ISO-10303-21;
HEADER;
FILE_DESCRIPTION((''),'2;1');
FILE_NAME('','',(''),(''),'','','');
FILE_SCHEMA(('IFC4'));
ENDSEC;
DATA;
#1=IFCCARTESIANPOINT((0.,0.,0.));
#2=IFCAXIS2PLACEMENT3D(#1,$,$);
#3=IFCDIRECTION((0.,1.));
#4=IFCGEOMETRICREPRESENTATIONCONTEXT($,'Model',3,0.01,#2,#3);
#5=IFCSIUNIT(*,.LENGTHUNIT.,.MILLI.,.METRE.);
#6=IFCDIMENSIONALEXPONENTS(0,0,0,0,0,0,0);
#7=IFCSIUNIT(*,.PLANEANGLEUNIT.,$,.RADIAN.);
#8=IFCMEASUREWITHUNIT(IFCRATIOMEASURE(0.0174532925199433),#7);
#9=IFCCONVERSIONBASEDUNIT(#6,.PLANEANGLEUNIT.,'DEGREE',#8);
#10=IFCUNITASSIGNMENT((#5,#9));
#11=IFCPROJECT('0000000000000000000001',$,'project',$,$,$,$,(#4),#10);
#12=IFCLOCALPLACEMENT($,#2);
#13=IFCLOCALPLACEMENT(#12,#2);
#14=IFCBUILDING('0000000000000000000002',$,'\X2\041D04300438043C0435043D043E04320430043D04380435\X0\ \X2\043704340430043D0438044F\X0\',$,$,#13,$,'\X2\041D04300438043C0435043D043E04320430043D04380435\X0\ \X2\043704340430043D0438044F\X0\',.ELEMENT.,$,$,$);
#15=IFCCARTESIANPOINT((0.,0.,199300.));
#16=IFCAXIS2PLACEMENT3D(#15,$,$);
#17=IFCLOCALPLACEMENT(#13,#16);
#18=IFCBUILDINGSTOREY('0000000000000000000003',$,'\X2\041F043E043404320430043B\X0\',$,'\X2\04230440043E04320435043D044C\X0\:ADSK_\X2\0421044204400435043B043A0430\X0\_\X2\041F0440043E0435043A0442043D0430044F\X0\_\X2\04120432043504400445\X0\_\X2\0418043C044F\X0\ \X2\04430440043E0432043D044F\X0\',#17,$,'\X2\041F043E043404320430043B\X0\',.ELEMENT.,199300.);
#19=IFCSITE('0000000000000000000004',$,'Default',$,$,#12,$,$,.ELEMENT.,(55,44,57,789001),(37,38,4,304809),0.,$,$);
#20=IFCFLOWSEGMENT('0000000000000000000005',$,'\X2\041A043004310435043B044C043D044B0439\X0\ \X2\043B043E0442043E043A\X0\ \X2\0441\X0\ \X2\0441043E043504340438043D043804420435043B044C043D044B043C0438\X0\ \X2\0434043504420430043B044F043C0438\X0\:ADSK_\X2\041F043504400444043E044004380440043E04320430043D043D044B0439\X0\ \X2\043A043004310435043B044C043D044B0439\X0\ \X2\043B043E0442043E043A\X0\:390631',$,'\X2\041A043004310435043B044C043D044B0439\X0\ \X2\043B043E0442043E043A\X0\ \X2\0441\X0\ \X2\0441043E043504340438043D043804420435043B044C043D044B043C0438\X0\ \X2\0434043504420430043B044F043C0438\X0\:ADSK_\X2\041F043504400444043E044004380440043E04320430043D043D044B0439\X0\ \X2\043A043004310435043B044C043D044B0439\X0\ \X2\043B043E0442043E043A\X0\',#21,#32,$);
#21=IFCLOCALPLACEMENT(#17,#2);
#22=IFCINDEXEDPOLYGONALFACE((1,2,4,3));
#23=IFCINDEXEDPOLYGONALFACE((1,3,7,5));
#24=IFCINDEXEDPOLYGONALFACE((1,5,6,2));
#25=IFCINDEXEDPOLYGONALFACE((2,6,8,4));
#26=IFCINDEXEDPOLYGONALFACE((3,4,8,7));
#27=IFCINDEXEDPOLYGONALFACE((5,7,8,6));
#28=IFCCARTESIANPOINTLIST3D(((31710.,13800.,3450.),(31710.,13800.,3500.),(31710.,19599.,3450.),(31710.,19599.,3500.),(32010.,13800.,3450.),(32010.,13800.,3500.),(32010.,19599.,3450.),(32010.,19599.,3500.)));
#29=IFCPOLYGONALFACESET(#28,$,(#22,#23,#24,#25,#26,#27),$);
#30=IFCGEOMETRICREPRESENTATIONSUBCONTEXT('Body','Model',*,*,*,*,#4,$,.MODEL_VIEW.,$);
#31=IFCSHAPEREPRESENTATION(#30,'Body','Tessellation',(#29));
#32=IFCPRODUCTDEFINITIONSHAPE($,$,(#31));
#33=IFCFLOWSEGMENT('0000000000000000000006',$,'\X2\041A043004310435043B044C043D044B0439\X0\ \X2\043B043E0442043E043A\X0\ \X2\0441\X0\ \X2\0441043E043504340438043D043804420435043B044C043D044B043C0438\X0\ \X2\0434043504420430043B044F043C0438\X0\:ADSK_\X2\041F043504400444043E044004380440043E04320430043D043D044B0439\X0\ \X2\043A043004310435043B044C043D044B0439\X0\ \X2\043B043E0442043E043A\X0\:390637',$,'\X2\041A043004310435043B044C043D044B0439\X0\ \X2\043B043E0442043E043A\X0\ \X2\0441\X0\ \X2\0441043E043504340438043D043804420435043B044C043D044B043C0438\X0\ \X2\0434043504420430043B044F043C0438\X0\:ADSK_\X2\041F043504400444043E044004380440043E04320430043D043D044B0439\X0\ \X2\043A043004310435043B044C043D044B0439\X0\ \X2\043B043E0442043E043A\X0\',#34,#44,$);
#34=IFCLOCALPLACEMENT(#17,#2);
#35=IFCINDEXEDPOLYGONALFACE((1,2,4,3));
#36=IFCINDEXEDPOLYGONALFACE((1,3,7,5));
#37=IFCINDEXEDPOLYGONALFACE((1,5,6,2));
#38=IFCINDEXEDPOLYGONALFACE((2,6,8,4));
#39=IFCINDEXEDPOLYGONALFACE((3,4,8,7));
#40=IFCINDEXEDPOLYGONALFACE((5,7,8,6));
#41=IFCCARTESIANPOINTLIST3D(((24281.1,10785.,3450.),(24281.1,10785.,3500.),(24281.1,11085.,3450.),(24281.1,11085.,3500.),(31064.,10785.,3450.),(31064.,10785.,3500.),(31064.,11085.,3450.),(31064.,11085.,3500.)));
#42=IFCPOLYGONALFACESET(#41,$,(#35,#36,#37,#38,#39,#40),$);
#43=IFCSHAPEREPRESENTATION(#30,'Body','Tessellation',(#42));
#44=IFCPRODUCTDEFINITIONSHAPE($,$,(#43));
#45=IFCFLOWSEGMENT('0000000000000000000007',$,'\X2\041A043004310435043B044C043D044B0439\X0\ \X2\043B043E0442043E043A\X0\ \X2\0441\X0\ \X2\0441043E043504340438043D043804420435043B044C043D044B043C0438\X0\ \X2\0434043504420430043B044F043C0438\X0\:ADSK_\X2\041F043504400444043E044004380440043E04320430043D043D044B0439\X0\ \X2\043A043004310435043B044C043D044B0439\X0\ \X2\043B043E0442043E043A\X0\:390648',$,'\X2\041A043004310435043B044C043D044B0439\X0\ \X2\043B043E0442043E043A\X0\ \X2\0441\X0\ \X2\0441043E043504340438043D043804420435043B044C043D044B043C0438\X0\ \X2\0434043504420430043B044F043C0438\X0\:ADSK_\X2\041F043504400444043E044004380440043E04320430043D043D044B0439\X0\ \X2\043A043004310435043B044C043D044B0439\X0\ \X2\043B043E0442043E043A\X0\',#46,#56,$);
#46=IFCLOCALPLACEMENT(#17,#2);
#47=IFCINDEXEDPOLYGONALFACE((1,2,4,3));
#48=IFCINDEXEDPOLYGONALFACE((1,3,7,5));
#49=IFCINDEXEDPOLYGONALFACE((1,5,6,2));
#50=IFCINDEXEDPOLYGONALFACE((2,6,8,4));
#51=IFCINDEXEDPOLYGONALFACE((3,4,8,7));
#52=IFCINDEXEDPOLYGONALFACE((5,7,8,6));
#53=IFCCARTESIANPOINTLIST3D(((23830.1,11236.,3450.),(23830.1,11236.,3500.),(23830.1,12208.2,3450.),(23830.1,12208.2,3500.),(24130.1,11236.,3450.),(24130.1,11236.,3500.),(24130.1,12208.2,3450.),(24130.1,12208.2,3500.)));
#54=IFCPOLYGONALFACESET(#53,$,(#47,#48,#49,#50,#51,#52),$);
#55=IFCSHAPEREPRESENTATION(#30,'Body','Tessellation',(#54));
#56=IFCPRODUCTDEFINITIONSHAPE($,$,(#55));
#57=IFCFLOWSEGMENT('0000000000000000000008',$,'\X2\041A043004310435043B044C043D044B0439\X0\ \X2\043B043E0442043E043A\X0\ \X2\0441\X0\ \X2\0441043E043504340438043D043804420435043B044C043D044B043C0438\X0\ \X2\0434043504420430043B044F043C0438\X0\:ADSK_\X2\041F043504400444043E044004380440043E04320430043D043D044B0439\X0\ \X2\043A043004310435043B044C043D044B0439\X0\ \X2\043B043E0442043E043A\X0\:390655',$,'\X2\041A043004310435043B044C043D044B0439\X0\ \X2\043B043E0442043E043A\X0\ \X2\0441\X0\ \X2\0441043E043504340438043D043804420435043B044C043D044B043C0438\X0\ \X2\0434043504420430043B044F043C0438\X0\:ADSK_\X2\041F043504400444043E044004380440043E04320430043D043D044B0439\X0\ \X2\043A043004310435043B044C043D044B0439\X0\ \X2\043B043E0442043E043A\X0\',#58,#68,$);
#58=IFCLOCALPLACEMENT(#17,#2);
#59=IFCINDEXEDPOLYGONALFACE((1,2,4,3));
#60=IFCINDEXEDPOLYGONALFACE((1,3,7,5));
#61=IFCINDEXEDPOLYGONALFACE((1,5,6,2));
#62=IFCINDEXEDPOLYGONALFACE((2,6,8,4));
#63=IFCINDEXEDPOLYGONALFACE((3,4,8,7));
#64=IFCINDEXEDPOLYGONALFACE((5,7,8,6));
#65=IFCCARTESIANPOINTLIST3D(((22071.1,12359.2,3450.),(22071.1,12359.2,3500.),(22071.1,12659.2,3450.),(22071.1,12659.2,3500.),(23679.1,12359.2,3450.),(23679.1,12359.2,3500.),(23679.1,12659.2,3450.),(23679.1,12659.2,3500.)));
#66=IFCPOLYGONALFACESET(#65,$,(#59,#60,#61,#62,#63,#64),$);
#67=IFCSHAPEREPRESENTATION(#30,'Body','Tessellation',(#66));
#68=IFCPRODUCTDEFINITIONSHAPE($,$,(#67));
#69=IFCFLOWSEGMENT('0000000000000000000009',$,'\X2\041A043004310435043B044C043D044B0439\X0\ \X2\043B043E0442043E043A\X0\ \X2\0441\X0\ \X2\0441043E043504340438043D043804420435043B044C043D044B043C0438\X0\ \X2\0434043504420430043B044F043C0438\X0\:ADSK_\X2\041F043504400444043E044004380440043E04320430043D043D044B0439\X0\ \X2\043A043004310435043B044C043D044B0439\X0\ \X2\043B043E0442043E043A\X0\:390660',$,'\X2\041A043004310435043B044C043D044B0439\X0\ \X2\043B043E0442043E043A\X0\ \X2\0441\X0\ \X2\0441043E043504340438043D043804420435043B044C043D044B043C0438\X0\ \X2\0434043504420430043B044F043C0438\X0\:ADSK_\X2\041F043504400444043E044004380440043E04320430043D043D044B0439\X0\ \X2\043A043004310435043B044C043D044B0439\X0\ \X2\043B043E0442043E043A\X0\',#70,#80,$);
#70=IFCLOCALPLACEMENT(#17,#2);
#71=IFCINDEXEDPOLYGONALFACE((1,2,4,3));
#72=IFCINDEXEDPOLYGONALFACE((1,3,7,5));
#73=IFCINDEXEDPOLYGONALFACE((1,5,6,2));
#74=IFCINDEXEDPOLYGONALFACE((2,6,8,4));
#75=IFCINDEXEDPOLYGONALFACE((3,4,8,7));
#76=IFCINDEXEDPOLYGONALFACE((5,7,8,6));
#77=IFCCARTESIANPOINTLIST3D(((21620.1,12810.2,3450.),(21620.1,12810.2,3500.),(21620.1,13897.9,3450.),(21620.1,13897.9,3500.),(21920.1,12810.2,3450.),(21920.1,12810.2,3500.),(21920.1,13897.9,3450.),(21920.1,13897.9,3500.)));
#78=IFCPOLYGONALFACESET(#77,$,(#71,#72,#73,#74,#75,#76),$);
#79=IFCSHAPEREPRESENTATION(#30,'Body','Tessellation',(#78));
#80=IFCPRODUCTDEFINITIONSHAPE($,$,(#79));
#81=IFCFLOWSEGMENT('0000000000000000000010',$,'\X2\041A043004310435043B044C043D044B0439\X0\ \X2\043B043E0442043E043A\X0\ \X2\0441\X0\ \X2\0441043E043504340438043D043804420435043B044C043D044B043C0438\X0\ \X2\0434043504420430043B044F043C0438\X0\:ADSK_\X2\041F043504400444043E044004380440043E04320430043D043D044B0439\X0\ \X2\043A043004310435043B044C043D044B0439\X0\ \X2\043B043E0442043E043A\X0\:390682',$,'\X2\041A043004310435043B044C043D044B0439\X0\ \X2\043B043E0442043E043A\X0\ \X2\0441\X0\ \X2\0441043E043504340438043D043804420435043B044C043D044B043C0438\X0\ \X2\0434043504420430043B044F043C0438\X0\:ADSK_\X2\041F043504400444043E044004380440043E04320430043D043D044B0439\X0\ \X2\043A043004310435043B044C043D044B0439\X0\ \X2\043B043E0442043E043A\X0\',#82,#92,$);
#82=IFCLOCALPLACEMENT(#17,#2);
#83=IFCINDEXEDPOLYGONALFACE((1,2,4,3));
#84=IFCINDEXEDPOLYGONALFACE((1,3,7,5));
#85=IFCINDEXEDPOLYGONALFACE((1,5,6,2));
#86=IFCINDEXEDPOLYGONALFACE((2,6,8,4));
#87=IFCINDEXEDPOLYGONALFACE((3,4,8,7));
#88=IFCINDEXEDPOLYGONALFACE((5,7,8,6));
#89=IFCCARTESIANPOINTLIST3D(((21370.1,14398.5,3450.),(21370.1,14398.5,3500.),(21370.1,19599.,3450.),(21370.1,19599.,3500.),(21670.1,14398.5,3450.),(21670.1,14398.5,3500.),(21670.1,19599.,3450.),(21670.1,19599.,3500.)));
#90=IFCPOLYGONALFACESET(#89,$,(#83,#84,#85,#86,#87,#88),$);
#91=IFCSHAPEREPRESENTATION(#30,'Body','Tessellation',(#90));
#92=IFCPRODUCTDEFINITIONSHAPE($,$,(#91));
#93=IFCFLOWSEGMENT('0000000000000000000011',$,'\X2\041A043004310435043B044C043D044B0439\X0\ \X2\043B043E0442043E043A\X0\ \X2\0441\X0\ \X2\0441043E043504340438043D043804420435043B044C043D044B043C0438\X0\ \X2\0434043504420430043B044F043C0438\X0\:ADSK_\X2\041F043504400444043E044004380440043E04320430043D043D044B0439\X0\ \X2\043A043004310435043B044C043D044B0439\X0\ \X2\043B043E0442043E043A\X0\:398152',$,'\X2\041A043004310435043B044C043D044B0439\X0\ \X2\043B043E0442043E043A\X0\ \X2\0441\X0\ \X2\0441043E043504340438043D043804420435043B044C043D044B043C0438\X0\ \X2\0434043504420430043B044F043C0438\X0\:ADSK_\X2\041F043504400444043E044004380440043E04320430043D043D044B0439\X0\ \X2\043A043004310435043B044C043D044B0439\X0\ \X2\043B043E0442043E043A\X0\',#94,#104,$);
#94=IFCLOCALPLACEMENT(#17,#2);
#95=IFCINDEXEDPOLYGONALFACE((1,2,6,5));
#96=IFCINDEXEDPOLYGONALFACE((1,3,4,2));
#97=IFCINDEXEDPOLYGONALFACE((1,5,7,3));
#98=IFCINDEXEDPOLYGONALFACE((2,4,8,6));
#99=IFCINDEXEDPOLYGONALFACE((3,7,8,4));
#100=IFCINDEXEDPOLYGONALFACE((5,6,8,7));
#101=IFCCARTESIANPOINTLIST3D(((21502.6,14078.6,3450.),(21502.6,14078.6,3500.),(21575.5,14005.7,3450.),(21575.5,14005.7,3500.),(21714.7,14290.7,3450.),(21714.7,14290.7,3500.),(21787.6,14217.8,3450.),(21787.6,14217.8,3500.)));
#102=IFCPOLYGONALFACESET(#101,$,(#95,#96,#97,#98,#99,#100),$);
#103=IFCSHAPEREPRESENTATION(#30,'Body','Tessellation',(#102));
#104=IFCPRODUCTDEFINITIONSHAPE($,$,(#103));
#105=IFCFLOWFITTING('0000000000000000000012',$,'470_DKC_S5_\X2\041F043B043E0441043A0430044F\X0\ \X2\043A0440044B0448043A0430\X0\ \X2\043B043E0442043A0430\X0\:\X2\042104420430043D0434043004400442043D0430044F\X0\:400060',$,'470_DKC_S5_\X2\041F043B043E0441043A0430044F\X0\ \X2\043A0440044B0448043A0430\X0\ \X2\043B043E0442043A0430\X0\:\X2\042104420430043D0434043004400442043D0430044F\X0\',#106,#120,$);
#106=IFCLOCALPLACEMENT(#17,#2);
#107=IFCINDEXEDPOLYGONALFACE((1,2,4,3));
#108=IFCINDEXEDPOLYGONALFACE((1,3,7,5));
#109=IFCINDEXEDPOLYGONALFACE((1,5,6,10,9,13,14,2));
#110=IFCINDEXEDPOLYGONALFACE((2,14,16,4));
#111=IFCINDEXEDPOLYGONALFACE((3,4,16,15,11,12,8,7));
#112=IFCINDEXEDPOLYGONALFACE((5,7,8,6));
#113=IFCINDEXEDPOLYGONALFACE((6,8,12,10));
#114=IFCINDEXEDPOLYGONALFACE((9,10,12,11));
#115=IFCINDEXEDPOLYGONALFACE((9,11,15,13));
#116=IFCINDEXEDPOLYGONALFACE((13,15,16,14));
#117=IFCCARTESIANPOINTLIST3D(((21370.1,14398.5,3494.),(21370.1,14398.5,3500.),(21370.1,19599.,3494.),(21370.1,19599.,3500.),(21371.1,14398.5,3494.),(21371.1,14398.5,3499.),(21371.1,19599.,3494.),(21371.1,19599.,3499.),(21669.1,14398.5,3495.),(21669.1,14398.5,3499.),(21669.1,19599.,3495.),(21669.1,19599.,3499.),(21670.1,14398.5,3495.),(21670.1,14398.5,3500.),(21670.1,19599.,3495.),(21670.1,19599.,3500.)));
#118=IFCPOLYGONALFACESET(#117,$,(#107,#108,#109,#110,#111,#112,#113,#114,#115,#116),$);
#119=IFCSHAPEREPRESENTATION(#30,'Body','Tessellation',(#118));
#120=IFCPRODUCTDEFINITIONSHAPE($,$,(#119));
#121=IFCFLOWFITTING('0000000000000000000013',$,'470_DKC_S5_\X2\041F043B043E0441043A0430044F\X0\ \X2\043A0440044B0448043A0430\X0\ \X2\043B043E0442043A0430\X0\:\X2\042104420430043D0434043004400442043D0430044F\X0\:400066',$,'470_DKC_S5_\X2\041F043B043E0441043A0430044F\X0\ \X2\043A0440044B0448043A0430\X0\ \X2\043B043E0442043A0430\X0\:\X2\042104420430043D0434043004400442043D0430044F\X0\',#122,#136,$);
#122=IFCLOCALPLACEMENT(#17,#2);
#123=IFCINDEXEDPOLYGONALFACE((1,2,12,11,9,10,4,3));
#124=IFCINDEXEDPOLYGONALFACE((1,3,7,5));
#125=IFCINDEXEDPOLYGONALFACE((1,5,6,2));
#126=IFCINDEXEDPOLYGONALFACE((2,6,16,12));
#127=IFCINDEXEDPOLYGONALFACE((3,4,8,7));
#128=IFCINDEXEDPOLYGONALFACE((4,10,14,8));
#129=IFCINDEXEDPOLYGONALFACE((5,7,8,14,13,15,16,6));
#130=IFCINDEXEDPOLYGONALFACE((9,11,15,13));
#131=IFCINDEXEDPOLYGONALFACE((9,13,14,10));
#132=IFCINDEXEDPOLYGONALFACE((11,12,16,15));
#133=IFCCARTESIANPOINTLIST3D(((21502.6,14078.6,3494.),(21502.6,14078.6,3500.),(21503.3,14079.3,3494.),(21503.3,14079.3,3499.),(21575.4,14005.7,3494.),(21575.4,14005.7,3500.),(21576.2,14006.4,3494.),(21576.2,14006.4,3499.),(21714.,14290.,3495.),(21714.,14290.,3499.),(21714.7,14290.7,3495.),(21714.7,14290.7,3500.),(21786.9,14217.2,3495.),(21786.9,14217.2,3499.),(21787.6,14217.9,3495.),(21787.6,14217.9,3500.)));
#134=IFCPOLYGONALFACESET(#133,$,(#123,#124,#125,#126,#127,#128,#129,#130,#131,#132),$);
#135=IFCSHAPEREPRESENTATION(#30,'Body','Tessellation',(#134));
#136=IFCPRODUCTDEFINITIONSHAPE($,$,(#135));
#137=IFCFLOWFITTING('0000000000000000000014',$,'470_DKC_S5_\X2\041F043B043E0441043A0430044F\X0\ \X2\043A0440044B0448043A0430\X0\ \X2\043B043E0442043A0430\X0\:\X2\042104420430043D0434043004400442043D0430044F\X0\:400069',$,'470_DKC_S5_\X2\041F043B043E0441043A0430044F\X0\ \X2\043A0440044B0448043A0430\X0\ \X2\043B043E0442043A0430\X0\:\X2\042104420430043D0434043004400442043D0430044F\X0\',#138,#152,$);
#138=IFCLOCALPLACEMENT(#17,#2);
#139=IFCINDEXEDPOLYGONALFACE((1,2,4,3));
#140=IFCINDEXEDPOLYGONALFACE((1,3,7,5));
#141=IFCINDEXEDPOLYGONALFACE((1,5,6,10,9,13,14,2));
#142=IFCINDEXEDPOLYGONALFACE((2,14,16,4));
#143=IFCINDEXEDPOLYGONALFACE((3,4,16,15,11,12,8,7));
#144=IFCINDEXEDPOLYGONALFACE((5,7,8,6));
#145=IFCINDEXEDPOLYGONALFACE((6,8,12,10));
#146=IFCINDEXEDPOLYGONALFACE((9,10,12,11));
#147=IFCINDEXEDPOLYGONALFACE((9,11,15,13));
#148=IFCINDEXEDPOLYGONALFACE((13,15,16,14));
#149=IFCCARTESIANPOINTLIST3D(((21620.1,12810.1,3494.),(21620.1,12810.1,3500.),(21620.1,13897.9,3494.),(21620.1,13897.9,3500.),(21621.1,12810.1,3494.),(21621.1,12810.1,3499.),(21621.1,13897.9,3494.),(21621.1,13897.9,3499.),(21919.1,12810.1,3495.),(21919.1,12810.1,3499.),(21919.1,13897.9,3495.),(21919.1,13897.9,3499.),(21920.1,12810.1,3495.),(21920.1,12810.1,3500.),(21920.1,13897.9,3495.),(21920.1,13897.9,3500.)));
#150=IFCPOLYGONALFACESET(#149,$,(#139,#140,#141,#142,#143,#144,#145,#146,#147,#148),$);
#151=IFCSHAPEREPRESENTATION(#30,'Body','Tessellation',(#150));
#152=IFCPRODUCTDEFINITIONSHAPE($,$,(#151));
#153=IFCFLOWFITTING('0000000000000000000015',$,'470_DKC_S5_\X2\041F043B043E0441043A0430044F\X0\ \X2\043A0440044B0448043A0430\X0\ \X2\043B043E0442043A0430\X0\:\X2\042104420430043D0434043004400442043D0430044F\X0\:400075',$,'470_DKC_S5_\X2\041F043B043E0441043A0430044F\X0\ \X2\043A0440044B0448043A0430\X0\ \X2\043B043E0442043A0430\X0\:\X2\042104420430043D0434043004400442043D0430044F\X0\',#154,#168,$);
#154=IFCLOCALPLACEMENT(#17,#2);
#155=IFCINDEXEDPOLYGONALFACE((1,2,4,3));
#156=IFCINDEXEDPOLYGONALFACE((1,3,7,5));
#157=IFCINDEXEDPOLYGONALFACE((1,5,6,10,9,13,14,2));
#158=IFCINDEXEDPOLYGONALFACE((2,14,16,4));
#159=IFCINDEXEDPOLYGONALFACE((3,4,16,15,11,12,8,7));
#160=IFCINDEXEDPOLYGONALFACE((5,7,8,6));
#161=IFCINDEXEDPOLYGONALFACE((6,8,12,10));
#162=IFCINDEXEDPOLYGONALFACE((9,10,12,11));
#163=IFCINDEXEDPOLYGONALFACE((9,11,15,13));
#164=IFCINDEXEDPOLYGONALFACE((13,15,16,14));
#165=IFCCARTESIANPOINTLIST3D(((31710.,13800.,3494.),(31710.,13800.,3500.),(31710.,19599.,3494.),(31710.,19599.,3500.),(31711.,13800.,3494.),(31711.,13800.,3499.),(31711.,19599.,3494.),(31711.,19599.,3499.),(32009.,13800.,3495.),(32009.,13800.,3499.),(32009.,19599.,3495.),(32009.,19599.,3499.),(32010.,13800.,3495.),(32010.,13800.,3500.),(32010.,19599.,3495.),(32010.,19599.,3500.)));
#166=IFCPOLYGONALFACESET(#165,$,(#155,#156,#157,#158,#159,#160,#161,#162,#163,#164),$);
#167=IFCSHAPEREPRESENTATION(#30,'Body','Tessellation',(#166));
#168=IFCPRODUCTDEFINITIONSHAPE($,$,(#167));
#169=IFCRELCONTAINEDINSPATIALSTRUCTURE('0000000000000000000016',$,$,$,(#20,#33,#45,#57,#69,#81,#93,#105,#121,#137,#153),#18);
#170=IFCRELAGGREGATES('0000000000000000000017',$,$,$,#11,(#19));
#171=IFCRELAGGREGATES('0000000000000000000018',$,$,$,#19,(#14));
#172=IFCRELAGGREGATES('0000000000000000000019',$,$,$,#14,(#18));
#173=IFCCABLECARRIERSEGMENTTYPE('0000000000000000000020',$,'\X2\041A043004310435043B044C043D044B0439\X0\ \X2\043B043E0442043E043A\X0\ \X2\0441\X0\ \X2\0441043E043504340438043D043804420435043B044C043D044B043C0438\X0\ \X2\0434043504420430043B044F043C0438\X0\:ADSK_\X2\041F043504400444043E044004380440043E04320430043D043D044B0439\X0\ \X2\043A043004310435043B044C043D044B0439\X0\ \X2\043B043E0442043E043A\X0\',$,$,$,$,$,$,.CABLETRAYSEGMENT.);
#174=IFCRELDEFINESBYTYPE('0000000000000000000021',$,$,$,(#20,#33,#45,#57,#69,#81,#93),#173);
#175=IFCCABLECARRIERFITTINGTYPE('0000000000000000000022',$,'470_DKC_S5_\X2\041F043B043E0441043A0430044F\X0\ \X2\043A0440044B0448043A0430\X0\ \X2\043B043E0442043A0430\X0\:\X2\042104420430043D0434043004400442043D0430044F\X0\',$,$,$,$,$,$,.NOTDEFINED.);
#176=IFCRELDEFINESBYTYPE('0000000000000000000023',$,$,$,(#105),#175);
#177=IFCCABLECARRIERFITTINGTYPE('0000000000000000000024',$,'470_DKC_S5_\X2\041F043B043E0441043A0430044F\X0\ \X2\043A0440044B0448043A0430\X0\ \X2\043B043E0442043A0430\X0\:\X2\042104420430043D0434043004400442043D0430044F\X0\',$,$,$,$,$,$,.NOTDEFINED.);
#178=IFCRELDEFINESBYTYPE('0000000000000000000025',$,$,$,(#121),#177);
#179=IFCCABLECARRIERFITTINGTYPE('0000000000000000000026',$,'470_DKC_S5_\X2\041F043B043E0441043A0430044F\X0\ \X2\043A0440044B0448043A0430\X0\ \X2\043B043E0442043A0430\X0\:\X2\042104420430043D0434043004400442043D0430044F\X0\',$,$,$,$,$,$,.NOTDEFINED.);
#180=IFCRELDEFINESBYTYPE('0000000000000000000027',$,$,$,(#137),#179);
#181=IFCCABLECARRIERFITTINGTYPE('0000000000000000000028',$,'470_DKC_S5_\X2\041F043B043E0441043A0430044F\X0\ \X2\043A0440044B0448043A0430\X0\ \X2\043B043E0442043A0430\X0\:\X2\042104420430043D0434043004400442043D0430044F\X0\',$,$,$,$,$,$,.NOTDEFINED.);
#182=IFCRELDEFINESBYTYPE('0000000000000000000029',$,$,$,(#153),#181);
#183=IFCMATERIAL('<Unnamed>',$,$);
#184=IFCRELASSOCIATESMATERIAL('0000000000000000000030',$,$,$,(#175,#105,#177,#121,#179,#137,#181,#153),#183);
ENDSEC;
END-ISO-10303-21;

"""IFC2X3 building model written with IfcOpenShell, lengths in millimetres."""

from ifc_helpers import new_model, entity, si_unit, converted_unit, direction, frame, frame_2d, origin, origin_2d_with_axis, place, context, subcontext, project, spatial, polyline, rectangle, outline, extrude, source, transform, mapped, material, type_object, type_shapes, element, save


model = new_model("IFC2X3")

# Units and contexts
model_context = context("Model", 3, precision=0.01, world=origin(), true_north=direction((0.0, 1.0)))
body_context = subcontext(model_context, "Body", "Model", "MODEL_VIEW")
ifc_project = project(units=[si_unit("LENGTHUNIT", "METRE", prefix="MILLI"), converted_unit("PLANEANGLEUNIT", "DEGREE", entity("IfcRatioMeasure", 0.0174532925199433), si_unit("PLANEANGLEUNIT", "RADIAN"), dimensions=[0, 0, 0, 0, 0, 0, 0])], contexts=[model_context])

# Site, building, storey
site_placement = place(None, origin())
site = spatial("IfcSite", under=ifc_project, at=site_placement, Name="Default", CompositionType="ELEMENT", RefLatitude=(55, 44, 57, 789001), RefLongitude=(37, 38, 4, 304809), RefElevation=0.0)
building_placement = place(site_placement, origin())
building = spatial("IfcBuilding", under=site, at=building_placement, Name="Наименование здания", LongName="Наименование здания", CompositionType="ELEMENT")
storey_placement = place(building_placement, frame((0.0, 0.0, 199300.0)))
storey = spatial("IfcBuildingStorey", under=building, at=storey_placement, Name="Подвал", ObjectType="Уровень:ADSK_Стрелка_Проектная_Вверх_Имя уровня", LongName="Подвал", CompositionType="ELEMENT", Elevation=199300.0)

# Flow segments
cable_carrier_segment_type = type_object("IfcCableCarrierSegmentType", Name="Кабельный лоток с соединительными деталями:ADSK_Перфорированный кабельный лоток", PredefinedType="CABLETRAYSEGMENT")
flow_segment_1_placement = place(storey_placement, frame((31710.0, 13800.0, 3450.0)))
element("IfcFlowSegment", 1, at=flow_segment_1_placement, inside=storey, type_object=cable_carrier_segment_type, Name="Кабельный лоток с соединительными деталями:ADSK_Перфорированный кабельный лоток:390631", ObjectType="Кабельный лоток с соединительными деталями:ADSK_Перфорированный кабельный лоток", context=body_context, shape_type="SweptSolid", body=[
    extrude(rectangle(XDim=5799.0, YDim=300.0, at=origin_2d_with_axis()), frame((150.0, 2899.5, 0.0), z_axis=(0.0, 0.0, 1.0), x_axis=(0.0, -1.0, 0.0)), (0.0, 0.0, 1.0), 50.0),
])
flow_segment_2_placement = place(storey_placement, frame((24281.1, 10785.0, 3450.0)))
element("IfcFlowSegment", 2, at=flow_segment_2_placement, inside=storey, type_object=cable_carrier_segment_type, Name="Кабельный лоток с соединительными деталями:ADSK_Перфорированный кабельный лоток:390637", ObjectType="Кабельный лоток с соединительными деталями:ADSK_Перфорированный кабельный лоток", context=body_context, shape_type="SweptSolid", body=[
    extrude(rectangle(XDim=6782.9, YDim=300.0, at=frame_2d((0.0, 0.0), x_axis=(1.0, 0.0))), frame((3391.5, 150.0, 0.0), z_axis=(0.0, 0.0, 1.0), x_axis=(-1.0, 0.0, 0.0)), (0.0, 0.0, 1.0), 50.0),
])
flow_segment_3_placement = place(storey_placement, frame((23830.1, 11236.0, 3450.0)))
element("IfcFlowSegment", 3, at=flow_segment_3_placement, inside=storey, type_object=cable_carrier_segment_type, Name="Кабельный лоток с соединительными деталями:ADSK_Перфорированный кабельный лоток:390648", ObjectType="Кабельный лоток с соединительными деталями:ADSK_Перфорированный кабельный лоток", context=body_context, shape_type="SweptSolid", body=[
    extrude(rectangle(XDim=972.2, YDim=300.0, at=origin_2d_with_axis()), frame((150.0, 486.1, 0.0), z_axis=(0.0, 0.0, 1.0), x_axis=(0.0, 1.0, 0.0)), (0.0, 0.0, 1.0), 50.0),
])
flow_segment_4_placement = place(storey_placement, frame((22071.1, 12359.2, 3450.0)))
element("IfcFlowSegment", 4, at=flow_segment_4_placement, inside=storey, type_object=cable_carrier_segment_type, Name="Кабельный лоток с соединительными деталями:ADSK_Перфорированный кабельный лоток:390655", ObjectType="Кабельный лоток с соединительными деталями:ADSK_Перфорированный кабельный лоток", context=body_context, shape_type="SweptSolid", body=[
    extrude(rectangle(XDim=1608.0, YDim=300.0, at=frame_2d((0.0, 0.0), x_axis=(1.0, 0.0))), frame((804.0, 150.0, 0.0), z_axis=(0.0, 0.0, 1.0), x_axis=(-1.0, 0.0, 0.0)), (0.0, 0.0, 1.0), 50.0),
])
flow_segment_5_placement = place(storey_placement, frame((21620.1, 12810.2, 3450.0)))
element("IfcFlowSegment", 5, at=flow_segment_5_placement, inside=storey, type_object=cable_carrier_segment_type, Name="Кабельный лоток с соединительными деталями:ADSK_Перфорированный кабельный лоток:390660", ObjectType="Кабельный лоток с соединительными деталями:ADSK_Перфорированный кабельный лоток", context=body_context, shape_type="SweptSolid", body=[
    extrude(rectangle(XDim=1087.8, YDim=300.0, at=frame_2d((0.0, 0.0), x_axis=(1.0, 0.0))), frame((150.0, 543.9, 0.0), z_axis=(0.0, 0.0, 1.0), x_axis=(0.0, 1.0, 0.0)), (0.0, 0.0, 1.0), 50.0),
])
flow_segment_6_placement = place(storey_placement, frame((21370.1, 14398.5, 3450.0)))
element("IfcFlowSegment", 6, at=flow_segment_6_placement, inside=storey, type_object=cable_carrier_segment_type, Name="Кабельный лоток с соединительными деталями:ADSK_Перфорированный кабельный лоток:390682", ObjectType="Кабельный лоток с соединительными деталями:ADSK_Перфорированный кабельный лоток", context=body_context, shape_type="SweptSolid", body=[
    extrude(rectangle(XDim=5200.5, YDim=300.0, at=origin_2d_with_axis()), frame((150.0, 2600.3, 0.0), z_axis=(0.0, 0.0, 1.0), x_axis=(0.0, -1.0, 0.0)), (0.0, 0.0, 1.0), 50.0),
])
flow_segment_7_placement = place(storey_placement, frame((21502.6, 14005.7, 3450.0)))
element("IfcFlowSegment", 7, at=flow_segment_7_placement, inside=storey, type_object=cable_carrier_segment_type, Name="Кабельный лоток с соединительными деталями:ADSK_Перфорированный кабельный лоток:398152", ObjectType="Кабельный лоток с соединительными деталями:ADSK_Перфорированный кабельный лоток", context=body_context, shape_type="SweptSolid", body=[
    extrude(rectangle(XDim=103.0, YDim=300.0, at=frame_2d((0.0, 0.0), x_axis=(1.0, 0.0))), frame((142.5, 142.5, 0.0), z_axis=(0.0, 0.0, 1.0), x_axis=(-0.707107, 0.707107, 0.0)), (0.0, 0.0, 1.0), 50.0),
])

# Flow fittings
ifc_material = material(Name="<Unnamed>")
cable_carrier_fitting_type_1 = type_object("IfcCableCarrierFittingType", Name="470_DKC_S5_Плоская крышка лотка:Стандартная", PredefinedType="NOTDEFINED", material=ifc_material)
shared_shape_1 = source(origin(), body_context, "Body", "SweptSolid", [
    extrude(outline(polyline([(-150.0, -2.0), (-149.0, -2.0), (-149.0, 2.0), (149.0, 2.0), (149.0, -3.0), (150.0, -3.0), (150.0, 3.0), (-150.0, 3.0), (-150.0, -2.0)])), frame((0.0, 150.0, 3.0), z_axis=(1.0, 0.0, 0.0), x_axis=(0.0, 1.0, 0.0)), (0.0, 0.0, 1.0), 5200.5),
])
type_shapes(cable_carrier_fitting_type_1, [shared_shape_1])
flow_fitting_1_placement = place(storey_placement, frame((21670.1, 14398.5, 3494.0), z_axis=(0.0, 0.0, 1.0), x_axis=(0.0, 1.0, 0.0)))
element("IfcFlowFitting", 8, at=flow_fitting_1_placement, inside=storey, type_object=cable_carrier_fitting_type_1, material=ifc_material, Name="470_DKC_S5_Плоская крышка лотка:Стандартная:400060", ObjectType="470_DKC_S5_Плоская крышка лотка:Стандартная", context=body_context, shape_type="MappedRepresentation", body=[
    mapped(shared_shape_1, transform((0.0, 0.0, 0.0), scale=1.0)),
])
cable_carrier_fitting_type_2 = type_object("IfcCableCarrierFittingType", Name="470_DKC_S5_Плоская крышка лотка:Стандартная", PredefinedType="NOTDEFINED", material=ifc_material)
shared_shape_2 = source(origin(), body_context, "Body", "SweptSolid", [
    extrude(outline(polyline([(-150.0, -2.0), (-149.0, -2.0), (-149.0, 2.0), (149.0, 2.0), (149.0, -3.0), (150.0, -3.0), (150.0, 3.0), (-150.0, 3.0), (-150.0, -2.0)])), frame((0.0, 150.0, 3.0), z_axis=(1.0, 0.0, 0.0), x_axis=(0.0, 1.0, 0.0)), (0.0, 0.0, 1.0), 103.0),
])
type_shapes(cable_carrier_fitting_type_2, [shared_shape_2])
flow_fitting_2_placement = place(storey_placement, frame((21787.6, 14217.9, 3494.0), z_axis=(0.0, 0.0, 1.0), x_axis=(-0.707107, 0.707107, 0.0)))
element("IfcFlowFitting", 9, at=flow_fitting_2_placement, inside=storey, type_object=cable_carrier_fitting_type_2, material=ifc_material, Name="470_DKC_S5_Плоская крышка лотка:Стандартная:400066", ObjectType="470_DKC_S5_Плоская крышка лотка:Стандартная", context=body_context, shape_type="MappedRepresentation", body=[
    mapped(shared_shape_2, transform((0.0, 0.0, 0.0), scale=1.0)),
])
cable_carrier_fitting_type_3 = type_object("IfcCableCarrierFittingType", Name="470_DKC_S5_Плоская крышка лотка:Стандартная", PredefinedType="NOTDEFINED", material=ifc_material)
shared_shape_3 = source(origin(), body_context, "Body", "SweptSolid", [
    extrude(outline(polyline([(-150.0, -2.0), (-149.0, -2.0), (-149.0, 2.0), (149.0, 2.0), (149.0, -3.0), (150.0, -3.0), (150.0, 3.0), (-150.0, 3.0), (-150.0, -2.0)])), frame((0.0, 150.0, 3.0), z_axis=(1.0, 0.0, 0.0), x_axis=(0.0, 1.0, 0.0)), (0.0, 0.0, 1.0), 1087.8),
])
type_shapes(cable_carrier_fitting_type_3, [shared_shape_3])
flow_fitting_3_placement = place(storey_placement, frame((21920.1, 12810.1, 3494.0), z_axis=(0.0, 0.0, 1.0), x_axis=(0.0, 1.0, 0.0)))
element("IfcFlowFitting", 10, at=flow_fitting_3_placement, inside=storey, type_object=cable_carrier_fitting_type_3, material=ifc_material, Name="470_DKC_S5_Плоская крышка лотка:Стандартная:400069", ObjectType="470_DKC_S5_Плоская крышка лотка:Стандартная", context=body_context, shape_type="MappedRepresentation", body=[
    mapped(shared_shape_3, transform((0.0, 0.0, 0.0), scale=1.0)),
])
cable_carrier_fitting_type_4 = type_object("IfcCableCarrierFittingType", Name="470_DKC_S5_Плоская крышка лотка:Стандартная", PredefinedType="NOTDEFINED", material=ifc_material)
shared_shape_4 = source(origin(), body_context, "Body", "SweptSolid", [
    extrude(outline(polyline([(-150.0, -2.0), (-149.0, -2.0), (-149.0, 2.0), (149.0, 2.0), (149.0, -3.0), (150.0, -3.0), (150.0, 3.0), (-150.0, 3.0), (-150.0, -2.0)])), frame((0.0, 150.0, 3.0), z_axis=(1.0, 0.0, 0.0), x_axis=(0.0, 1.0, 0.0)), (0.0, 0.0, 1.0), 5799.0),
])
type_shapes(cable_carrier_fitting_type_4, [shared_shape_4])
flow_fitting_4_placement = place(storey_placement, frame((32010.0, 13800.0, 3494.0), z_axis=(0.0, 0.0, 1.0), x_axis=(0.0, 1.0, 0.0)))
element("IfcFlowFitting", 11, at=flow_fitting_4_placement, inside=storey, type_object=cable_carrier_fitting_type_4, material=ifc_material, Name="470_DKC_S5_Плоская крышка лотка:Стандартная:400075", ObjectType="470_DKC_S5_Плоская крышка лотка:Стандартная", context=body_context, shape_type="MappedRepresentation", body=[
    mapped(shared_shape_4, transform((0.0, 0.0, 0.0), scale=1.0)),
])

save(model, "model.ifc")
